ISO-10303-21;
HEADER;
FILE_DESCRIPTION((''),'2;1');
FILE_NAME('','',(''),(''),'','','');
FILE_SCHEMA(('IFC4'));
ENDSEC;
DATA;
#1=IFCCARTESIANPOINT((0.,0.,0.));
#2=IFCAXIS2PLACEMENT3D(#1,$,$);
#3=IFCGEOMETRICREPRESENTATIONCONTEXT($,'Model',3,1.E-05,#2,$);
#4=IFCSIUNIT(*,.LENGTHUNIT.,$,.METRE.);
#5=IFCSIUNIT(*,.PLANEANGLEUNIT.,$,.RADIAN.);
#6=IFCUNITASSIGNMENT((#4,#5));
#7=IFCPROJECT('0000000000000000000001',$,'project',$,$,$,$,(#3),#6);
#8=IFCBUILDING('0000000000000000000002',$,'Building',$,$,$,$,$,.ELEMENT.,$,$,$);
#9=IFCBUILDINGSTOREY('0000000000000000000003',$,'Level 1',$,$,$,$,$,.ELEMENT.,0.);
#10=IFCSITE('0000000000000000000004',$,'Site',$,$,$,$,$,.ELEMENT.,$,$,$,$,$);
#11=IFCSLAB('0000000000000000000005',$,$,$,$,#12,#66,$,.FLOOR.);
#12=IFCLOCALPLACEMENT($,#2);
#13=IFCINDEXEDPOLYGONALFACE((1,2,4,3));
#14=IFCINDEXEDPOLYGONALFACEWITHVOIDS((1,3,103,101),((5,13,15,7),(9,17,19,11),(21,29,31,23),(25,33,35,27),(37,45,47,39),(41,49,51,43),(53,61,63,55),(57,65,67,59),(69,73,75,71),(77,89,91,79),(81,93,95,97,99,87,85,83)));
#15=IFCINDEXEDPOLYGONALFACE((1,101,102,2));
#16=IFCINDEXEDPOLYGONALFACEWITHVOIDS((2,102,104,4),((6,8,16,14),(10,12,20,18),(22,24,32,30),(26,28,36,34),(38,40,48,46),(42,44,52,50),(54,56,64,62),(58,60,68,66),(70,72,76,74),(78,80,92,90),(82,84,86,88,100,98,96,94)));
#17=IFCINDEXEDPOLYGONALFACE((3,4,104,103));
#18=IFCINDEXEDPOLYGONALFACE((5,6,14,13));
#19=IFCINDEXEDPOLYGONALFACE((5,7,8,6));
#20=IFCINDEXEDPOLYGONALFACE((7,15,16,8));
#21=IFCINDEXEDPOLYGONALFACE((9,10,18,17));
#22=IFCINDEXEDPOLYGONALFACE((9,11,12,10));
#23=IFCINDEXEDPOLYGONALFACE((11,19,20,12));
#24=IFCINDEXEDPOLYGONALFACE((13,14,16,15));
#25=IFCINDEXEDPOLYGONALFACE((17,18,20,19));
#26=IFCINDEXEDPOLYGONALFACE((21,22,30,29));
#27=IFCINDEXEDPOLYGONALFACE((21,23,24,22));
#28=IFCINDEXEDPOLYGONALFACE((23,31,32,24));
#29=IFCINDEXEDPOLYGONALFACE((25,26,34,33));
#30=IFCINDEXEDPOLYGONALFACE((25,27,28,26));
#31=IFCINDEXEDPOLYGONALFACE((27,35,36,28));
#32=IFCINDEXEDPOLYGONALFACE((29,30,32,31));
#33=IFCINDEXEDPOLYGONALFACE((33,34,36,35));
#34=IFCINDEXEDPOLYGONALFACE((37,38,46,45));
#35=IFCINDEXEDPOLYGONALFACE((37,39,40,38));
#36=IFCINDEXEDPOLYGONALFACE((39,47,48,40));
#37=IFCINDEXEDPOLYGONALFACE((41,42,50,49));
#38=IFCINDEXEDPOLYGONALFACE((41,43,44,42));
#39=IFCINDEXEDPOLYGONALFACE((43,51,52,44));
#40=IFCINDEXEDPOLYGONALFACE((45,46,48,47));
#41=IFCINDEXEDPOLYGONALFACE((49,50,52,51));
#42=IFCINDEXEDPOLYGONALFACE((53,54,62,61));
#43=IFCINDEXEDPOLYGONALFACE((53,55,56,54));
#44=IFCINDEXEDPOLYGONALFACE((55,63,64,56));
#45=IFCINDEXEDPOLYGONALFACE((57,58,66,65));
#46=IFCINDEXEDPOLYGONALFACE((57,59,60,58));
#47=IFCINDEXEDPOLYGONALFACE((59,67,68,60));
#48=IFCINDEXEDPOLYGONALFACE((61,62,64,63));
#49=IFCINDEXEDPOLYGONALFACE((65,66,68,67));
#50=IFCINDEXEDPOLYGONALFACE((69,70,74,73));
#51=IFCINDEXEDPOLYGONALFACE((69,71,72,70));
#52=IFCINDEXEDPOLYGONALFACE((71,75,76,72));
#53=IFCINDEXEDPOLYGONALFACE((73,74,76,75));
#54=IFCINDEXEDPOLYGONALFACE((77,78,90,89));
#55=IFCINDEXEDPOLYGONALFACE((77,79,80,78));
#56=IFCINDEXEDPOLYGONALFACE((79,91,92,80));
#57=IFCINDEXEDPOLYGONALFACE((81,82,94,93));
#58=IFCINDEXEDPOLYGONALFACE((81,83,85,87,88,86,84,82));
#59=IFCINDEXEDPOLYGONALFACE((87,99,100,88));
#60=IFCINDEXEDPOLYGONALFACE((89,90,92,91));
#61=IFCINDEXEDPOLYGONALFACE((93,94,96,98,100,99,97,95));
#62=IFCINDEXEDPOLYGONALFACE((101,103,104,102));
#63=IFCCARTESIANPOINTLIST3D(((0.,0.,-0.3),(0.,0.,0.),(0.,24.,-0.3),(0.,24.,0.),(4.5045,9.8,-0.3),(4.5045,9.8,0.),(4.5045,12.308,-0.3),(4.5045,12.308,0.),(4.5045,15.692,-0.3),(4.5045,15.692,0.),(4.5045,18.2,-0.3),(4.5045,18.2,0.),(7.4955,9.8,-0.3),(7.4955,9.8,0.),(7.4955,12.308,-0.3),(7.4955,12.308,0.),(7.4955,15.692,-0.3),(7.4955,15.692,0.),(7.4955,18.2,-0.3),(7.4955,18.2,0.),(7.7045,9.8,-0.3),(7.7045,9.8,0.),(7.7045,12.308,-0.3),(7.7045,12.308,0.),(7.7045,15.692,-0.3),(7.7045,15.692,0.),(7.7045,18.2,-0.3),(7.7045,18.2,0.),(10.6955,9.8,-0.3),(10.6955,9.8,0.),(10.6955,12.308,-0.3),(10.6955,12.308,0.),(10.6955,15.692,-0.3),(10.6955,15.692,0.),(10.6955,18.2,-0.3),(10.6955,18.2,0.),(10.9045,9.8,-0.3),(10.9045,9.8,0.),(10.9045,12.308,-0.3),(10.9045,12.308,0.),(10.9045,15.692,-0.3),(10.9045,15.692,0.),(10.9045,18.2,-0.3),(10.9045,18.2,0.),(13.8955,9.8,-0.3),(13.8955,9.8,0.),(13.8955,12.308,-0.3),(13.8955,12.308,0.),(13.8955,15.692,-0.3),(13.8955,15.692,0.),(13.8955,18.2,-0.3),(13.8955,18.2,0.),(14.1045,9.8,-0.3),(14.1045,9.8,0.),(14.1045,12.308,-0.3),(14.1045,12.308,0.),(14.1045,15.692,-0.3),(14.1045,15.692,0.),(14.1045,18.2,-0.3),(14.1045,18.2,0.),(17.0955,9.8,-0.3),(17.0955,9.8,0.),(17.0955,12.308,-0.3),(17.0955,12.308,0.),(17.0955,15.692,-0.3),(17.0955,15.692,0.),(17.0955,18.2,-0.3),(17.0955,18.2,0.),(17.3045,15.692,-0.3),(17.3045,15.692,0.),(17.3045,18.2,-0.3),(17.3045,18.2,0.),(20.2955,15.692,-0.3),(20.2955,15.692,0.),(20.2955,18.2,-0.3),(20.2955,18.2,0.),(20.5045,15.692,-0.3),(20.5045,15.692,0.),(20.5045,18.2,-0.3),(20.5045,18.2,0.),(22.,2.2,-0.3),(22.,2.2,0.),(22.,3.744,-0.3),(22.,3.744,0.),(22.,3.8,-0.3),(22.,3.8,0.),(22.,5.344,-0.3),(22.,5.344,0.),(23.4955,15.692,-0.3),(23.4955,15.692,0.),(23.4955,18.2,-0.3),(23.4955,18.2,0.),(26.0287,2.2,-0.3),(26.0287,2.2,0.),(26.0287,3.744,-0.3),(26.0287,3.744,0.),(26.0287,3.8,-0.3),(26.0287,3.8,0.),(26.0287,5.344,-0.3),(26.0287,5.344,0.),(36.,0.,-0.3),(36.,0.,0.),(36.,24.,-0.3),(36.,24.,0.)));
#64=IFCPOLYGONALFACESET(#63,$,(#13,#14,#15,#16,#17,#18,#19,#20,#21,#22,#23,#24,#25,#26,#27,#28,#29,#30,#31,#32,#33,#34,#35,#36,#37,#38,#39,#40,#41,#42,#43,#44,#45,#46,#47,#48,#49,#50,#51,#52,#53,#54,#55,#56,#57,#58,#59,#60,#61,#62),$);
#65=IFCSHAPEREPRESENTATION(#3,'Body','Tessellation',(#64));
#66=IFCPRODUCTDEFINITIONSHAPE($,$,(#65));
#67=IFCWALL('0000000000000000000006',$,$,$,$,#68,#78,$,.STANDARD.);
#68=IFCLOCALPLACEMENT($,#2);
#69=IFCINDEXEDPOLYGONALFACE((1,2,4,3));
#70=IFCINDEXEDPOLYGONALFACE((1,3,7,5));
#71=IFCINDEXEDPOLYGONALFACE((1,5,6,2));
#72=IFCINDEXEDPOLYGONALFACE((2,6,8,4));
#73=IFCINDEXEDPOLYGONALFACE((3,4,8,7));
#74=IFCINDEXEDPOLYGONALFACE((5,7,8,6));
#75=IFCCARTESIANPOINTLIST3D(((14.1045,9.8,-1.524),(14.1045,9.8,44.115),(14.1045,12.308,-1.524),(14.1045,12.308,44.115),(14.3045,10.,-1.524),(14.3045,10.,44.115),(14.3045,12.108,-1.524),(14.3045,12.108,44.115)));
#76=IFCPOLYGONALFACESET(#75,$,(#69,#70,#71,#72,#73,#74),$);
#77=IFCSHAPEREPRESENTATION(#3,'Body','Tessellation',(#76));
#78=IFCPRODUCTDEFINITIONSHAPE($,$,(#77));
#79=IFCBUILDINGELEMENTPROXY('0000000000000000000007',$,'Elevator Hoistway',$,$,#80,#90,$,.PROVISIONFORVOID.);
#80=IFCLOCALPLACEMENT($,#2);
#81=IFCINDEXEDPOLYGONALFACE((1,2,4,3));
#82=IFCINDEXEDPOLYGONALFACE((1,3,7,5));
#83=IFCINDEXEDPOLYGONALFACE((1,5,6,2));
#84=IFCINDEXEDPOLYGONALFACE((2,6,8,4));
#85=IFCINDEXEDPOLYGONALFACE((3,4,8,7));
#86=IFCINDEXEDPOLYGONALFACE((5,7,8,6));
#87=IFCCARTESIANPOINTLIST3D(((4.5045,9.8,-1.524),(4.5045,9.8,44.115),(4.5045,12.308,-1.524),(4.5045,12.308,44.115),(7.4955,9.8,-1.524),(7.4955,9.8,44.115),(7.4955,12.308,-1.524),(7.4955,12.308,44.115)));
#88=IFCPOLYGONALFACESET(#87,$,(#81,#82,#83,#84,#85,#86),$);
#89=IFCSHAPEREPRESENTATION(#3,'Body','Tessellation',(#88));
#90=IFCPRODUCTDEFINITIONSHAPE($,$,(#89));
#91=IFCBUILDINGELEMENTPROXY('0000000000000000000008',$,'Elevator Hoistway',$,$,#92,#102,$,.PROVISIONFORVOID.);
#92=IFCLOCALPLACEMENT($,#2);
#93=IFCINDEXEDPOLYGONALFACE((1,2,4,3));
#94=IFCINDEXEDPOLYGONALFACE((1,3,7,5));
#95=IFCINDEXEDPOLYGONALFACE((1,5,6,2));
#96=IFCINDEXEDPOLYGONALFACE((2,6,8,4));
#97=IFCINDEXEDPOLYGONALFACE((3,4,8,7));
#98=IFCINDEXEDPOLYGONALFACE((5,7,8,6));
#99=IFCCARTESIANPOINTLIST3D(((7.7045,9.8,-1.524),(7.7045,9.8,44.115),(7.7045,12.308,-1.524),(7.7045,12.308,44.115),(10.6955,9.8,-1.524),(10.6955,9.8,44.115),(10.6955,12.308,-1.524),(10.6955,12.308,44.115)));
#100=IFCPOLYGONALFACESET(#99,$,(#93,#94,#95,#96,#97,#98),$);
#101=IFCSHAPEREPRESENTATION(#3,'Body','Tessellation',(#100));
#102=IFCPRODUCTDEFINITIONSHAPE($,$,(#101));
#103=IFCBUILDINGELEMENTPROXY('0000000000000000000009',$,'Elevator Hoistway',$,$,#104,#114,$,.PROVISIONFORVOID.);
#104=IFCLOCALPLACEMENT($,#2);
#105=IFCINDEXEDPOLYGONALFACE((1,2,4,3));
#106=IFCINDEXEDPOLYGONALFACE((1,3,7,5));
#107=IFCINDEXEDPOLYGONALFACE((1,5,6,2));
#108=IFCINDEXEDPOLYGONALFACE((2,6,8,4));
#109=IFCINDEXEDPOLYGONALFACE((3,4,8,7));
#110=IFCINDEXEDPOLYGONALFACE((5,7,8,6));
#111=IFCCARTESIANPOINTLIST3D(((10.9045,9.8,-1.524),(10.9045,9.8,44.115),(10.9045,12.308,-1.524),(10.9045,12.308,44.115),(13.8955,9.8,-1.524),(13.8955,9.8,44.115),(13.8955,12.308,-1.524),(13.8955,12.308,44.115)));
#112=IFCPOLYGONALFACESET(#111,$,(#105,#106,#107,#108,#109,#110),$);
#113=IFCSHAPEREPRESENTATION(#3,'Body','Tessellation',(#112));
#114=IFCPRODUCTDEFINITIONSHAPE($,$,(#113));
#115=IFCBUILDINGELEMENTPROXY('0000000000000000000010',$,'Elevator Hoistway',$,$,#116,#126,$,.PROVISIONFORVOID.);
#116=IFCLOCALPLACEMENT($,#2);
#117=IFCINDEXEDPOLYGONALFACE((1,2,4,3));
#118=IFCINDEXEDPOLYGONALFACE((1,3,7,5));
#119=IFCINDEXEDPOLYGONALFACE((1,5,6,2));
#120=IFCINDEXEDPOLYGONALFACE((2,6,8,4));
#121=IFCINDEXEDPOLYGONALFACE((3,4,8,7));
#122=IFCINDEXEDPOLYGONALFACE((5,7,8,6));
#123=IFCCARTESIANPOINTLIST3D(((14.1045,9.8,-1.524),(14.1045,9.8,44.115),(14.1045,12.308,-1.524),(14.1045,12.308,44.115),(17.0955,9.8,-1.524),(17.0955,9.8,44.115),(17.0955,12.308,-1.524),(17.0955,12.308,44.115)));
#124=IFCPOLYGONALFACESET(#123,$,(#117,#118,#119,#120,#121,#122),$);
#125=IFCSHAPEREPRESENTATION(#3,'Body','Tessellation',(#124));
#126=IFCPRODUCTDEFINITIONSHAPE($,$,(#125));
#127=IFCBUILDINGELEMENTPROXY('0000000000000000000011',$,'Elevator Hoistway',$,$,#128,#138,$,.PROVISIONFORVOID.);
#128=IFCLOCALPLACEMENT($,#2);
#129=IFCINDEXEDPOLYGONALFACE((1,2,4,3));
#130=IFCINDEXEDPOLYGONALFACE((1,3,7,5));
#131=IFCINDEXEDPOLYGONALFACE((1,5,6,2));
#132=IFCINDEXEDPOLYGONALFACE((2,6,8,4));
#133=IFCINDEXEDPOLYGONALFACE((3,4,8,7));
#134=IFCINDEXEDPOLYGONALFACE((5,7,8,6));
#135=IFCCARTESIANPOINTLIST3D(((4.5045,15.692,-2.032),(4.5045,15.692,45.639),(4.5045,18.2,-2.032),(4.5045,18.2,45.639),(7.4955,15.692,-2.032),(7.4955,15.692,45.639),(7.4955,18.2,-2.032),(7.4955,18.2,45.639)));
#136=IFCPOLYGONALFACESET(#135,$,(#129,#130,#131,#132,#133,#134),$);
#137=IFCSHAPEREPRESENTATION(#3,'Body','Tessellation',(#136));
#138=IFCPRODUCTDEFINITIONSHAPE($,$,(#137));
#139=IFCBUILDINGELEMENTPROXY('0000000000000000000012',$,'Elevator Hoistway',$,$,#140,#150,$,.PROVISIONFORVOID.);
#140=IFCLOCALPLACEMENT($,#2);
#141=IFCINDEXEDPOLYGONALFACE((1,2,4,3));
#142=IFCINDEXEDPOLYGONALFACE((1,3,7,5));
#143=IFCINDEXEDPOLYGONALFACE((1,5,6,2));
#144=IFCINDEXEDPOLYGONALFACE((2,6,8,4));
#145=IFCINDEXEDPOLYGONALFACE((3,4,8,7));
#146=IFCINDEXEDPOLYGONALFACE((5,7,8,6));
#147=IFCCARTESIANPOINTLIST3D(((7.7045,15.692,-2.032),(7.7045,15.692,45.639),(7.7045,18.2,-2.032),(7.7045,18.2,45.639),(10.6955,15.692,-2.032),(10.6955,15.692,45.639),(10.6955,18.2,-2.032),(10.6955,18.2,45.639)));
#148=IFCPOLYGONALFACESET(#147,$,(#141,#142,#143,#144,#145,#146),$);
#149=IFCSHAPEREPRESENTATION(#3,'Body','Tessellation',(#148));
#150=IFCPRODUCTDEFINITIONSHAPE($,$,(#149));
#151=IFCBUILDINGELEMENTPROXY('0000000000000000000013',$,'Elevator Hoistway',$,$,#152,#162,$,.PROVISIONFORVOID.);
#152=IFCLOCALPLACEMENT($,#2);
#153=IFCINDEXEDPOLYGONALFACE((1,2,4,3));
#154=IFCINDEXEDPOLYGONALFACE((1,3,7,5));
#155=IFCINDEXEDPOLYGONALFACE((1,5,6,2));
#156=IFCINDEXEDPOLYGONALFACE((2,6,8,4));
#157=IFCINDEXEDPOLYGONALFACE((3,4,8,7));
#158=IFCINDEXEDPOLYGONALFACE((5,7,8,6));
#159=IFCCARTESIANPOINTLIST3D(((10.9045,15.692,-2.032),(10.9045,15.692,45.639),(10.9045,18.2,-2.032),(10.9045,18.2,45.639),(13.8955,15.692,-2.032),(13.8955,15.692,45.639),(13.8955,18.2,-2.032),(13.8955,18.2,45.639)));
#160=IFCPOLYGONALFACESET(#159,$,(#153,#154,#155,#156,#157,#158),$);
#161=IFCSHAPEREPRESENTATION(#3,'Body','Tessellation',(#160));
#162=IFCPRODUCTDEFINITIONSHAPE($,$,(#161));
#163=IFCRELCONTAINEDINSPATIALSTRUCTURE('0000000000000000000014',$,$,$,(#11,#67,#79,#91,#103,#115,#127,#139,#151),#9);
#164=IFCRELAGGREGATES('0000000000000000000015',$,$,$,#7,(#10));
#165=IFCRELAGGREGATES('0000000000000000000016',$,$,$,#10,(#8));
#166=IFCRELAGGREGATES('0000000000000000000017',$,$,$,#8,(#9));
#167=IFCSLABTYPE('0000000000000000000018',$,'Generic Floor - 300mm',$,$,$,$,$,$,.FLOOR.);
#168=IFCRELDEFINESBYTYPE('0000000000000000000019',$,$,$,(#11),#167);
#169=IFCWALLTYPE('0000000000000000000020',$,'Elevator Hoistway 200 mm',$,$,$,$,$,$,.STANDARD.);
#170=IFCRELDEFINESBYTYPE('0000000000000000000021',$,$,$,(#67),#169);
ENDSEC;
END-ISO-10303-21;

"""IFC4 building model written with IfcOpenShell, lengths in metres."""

from ifc_helpers import new_model, si_unit, frame, origin, place, context, project, spatial, polyline, outline, extrude, type_object, element, save


model = new_model("IFC4")

# Units and contexts
model_context = context("Model", 3, precision=1e-05, world=origin())
ifc_project = project(units=[si_unit("LENGTHUNIT", "METRE"), si_unit("PLANEANGLEUNIT", "RADIAN")], contexts=[model_context])

# Site, building, storey
site = spatial("IfcSite", under=ifc_project, Name="Site", CompositionType="ELEMENT")
building = spatial("IfcBuilding", under=site, Name="Building", CompositionType="ELEMENT")
storey = spatial("IfcBuildingStorey", under=building, Name="Level 1", CompositionType="ELEMENT", Elevation=0.0)

# Slab, openings
slab_type = type_object("IfcSlabType", Name="Generic Floor - 300mm", PredefinedType="FLOOR")
slab_placement = place(None, origin())
slab = element("IfcSlab", 1, at=slab_placement, inside=storey, type_object=slab_type, PredefinedType="FLOOR", context=model_context, shape_type="SweptSolid", body=[
    extrude(outline(polyline([(0.0, 0.0), (36.0, 0.0), (36.0, 24.0), (0.0, 24.0), (0.0, 0.0)])), origin(), (0.0, 0.0, -1.0), 0.3),
])
opening_1_placement = place(None, frame((0.0, 0.0, 0.001)))
element("IfcOpeningElement", 2, at=opening_1_placement, cuts=slab, PredefinedType="OPENING", context=model_context, shape_type="SweptSolid", body=[
    extrude(outline(polyline([(4.5045, 9.8), (7.4955, 9.8), (7.4955, 12.308), (4.5045, 12.308), (4.5045, 9.8)])), origin(), (0.0, 0.0, -1.0), 0.302),
])
opening_2_placement = place(None, frame((0.0, 0.0, 0.001)))
element("IfcOpeningElement", 3, at=opening_2_placement, cuts=slab, PredefinedType="OPENING", context=model_context, shape_type="SweptSolid", body=[
    extrude(outline(polyline([(7.7045, 9.8), (10.6955, 9.8), (10.6955, 12.308), (7.7045, 12.308), (7.7045, 9.8)])), origin(), (0.0, 0.0, -1.0), 0.302),
])
opening_3_placement = place(None, frame((0.0, 0.0, 0.001)))
element("IfcOpeningElement", 4, at=opening_3_placement, cuts=slab, PredefinedType="OPENING", context=model_context, shape_type="SweptSolid", body=[
    extrude(outline(polyline([(10.9045, 9.8), (13.8955, 9.8), (13.8955, 12.308), (10.9045, 12.308), (10.9045, 9.8)])), origin(), (0.0, 0.0, -1.0), 0.302),
])
opening_4_placement = place(None, frame((0.0, 0.0, 0.001)))
element("IfcOpeningElement", 5, at=opening_4_placement, cuts=slab, PredefinedType="OPENING", context=model_context, shape_type="SweptSolid", body=[
    extrude(outline(polyline([(14.1045, 9.8), (17.0955, 9.8), (17.0955, 12.308), (14.1045, 12.308), (14.1045, 9.8)])), origin(), (0.0, 0.0, -1.0), 0.302),
])
opening_5_placement = place(None, frame((0.0, 0.0, 0.001)))
element("IfcOpeningElement", 6, at=opening_5_placement, cuts=slab, PredefinedType="OPENING", context=model_context, shape_type="SweptSolid", body=[
    extrude(outline(polyline([(7.4955, 18.2), (4.5045, 18.2), (4.5045, 15.692), (7.4955, 15.692), (7.4955, 18.2)])), origin(), (0.0, 0.0, -1.0), 0.302),
])
opening_6_placement = place(None, frame((0.0, 0.0, 0.001)))
element("IfcOpeningElement", 7, at=opening_6_placement, cuts=slab, PredefinedType="OPENING", context=model_context, shape_type="SweptSolid", body=[
    extrude(outline(polyline([(10.6955, 18.2), (7.7045, 18.2), (7.7045, 15.692), (10.6955, 15.692), (10.6955, 18.2)])), origin(), (0.0, 0.0, -1.0), 0.302),
])
opening_7_placement = place(None, frame((0.0, 0.0, 0.001)))
element("IfcOpeningElement", 8, at=opening_7_placement, cuts=slab, PredefinedType="OPENING", context=model_context, shape_type="SweptSolid", body=[
    extrude(outline(polyline([(13.8955, 18.2), (10.9045, 18.2), (10.9045, 15.692), (13.8955, 15.692), (13.8955, 18.2)])), origin(), (0.0, 0.0, -1.0), 0.302),
])
opening_8_placement = place(None, frame((0.0, 0.0, 0.001)))
element("IfcOpeningElement", 9, at=opening_8_placement, cuts=slab, PredefinedType="OPENING", context=model_context, shape_type="SweptSolid", body=[
    extrude(outline(polyline([(17.0955, 18.2), (14.1045, 18.2), (14.1045, 15.692), (17.0955, 15.692), (17.0955, 18.2)])), origin(), (0.0, 0.0, -1.0), 0.302),
])
opening_9_placement = place(None, frame((0.0, 0.0, 0.001)))
element("IfcOpeningElement", 10, at=opening_9_placement, cuts=slab, PredefinedType="OPENING", context=model_context, shape_type="SweptSolid", body=[
    extrude(outline(polyline([(20.2955, 18.2), (17.3045, 18.2), (17.3045, 15.692), (20.2955, 15.692), (20.2955, 18.2)])), origin(), (0.0, 0.0, -1.0), 0.302),
])
opening_10_placement = place(None, frame((0.0, 0.0, 0.001)))
element("IfcOpeningElement", 11, at=opening_10_placement, cuts=slab, PredefinedType="OPENING", context=model_context, shape_type="SweptSolid", body=[
    extrude(outline(polyline([(23.4955, 18.2), (20.5045, 18.2), (20.5045, 15.692), (23.4955, 15.692), (23.4955, 18.2)])), origin(), (0.0, 0.0, -1.0), 0.302),
])
opening_11_placement = place(None, frame((0.0, 0.0, 0.001)))
element("IfcOpeningElement", 12, at=opening_11_placement, cuts=slab, PredefinedType="OPENING", context=model_context, shape_type="SweptSolid", body=[
    extrude(outline(polyline([(22.0, 2.2), (26.0287, 2.2), (26.0287, 3.8), (22.0, 3.8), (22.0, 2.2)])), origin(), (0.0, 0.0, -1.0), 0.302),
])
opening_12_placement = place(None, frame((0.0, 0.0, 0.001)))
element("IfcOpeningElement", 13, at=opening_12_placement, cuts=slab, PredefinedType="OPENING", context=model_context, shape_type="SweptSolid", body=[
    extrude(outline(polyline([(22.0, 3.744), (26.0287, 3.744), (26.0287, 5.344), (22.0, 5.344), (22.0, 3.744)])), origin(), (0.0, 0.0, -1.0), 0.302),
])

# Wall
wall_type = type_object("IfcWallType", Name="Elevator Hoistway 200 mm", PredefinedType="STANDARD")
wall_placement = place(None, frame((14.2045, 12.208, -1.524), z_axis=(0.0, 0.0, 1.0), x_axis=(0.0, -1.0, 0.0)))
element("IfcWall", 14, at=wall_placement, inside=storey, type_object=wall_type, PredefinedType="STANDARD", context=model_context, shape_type="SweptSolid", body=[
    extrude(outline(polyline([(-0.1, -0.1), (2.408, -0.1), (2.208, 0.1), (0.1, 0.1), (-0.1, -0.1)])), origin(), (0.0, 0.0, 1.0), 45.639),
])

# Building element proxies
proxy_1_placement = place(None, frame((0.0, 0.0, 44.115)))
element("IfcBuildingElementProxy", 15, at=proxy_1_placement, inside=storey, Name="Elevator Hoistway", PredefinedType="PROVISIONFORVOID", context=model_context, shape_type="SweptSolid", body=[
    extrude(outline(polyline([(4.5045, 9.8), (7.4955, 9.8), (7.4955, 12.308), (4.5045, 12.308), (4.5045, 9.8)])), origin(), (0.0, 0.0, -1.0), 45.639),
])
proxy_2_placement = place(None, frame((0.0, 0.0, 44.115)))
element("IfcBuildingElementProxy", 16, at=proxy_2_placement, inside=storey, Name="Elevator Hoistway", PredefinedType="PROVISIONFORVOID", context=model_context, shape_type="SweptSolid", body=[
    extrude(outline(polyline([(7.7045, 9.8), (10.6955, 9.8), (10.6955, 12.308), (7.7045, 12.308), (7.7045, 9.8)])), origin(), (0.0, 0.0, -1.0), 45.639),
])
proxy_3_placement = place(None, frame((0.0, 0.0, 44.115)))
element("IfcBuildingElementProxy", 17, at=proxy_3_placement, inside=storey, Name="Elevator Hoistway", PredefinedType="PROVISIONFORVOID", context=model_context, shape_type="SweptSolid", body=[
    extrude(outline(polyline([(10.9045, 9.8), (13.8955, 9.8), (13.8955, 12.308), (10.9045, 12.308), (10.9045, 9.8)])), origin(), (0.0, 0.0, -1.0), 45.639),
])
proxy_4_placement = place(None, frame((0.0, 0.0, 44.115)))
element("IfcBuildingElementProxy", 18, at=proxy_4_placement, inside=storey, Name="Elevator Hoistway", PredefinedType="PROVISIONFORVOID", context=model_context, shape_type="SweptSolid", body=[
    extrude(outline(polyline([(14.1045, 9.8), (17.0955, 9.8), (17.0955, 12.308), (14.1045, 12.308), (14.1045, 9.8)])), origin(), (0.0, 0.0, -1.0), 45.639),
])
proxy_5_placement = place(None, frame((0.0, 0.0, 45.639)))
element("IfcBuildingElementProxy", 19, at=proxy_5_placement, inside=storey, Name="Elevator Hoistway", PredefinedType="PROVISIONFORVOID", context=model_context, shape_type="SweptSolid", body=[
    extrude(outline(polyline([(7.4955, 18.2), (4.5045, 18.2), (4.5045, 15.692), (7.4955, 15.692), (7.4955, 18.2)])), origin(), (0.0, 0.0, -1.0), 47.671),
])
proxy_6_placement = place(None, frame((0.0, 0.0, 45.639)))
element("IfcBuildingElementProxy", 20, at=proxy_6_placement, inside=storey, Name="Elevator Hoistway", PredefinedType="PROVISIONFORVOID", context=model_context, shape_type="SweptSolid", body=[
    extrude(outline(polyline([(10.6955, 18.2), (7.7045, 18.2), (7.7045, 15.692), (10.6955, 15.692), (10.6955, 18.2)])), origin(), (0.0, 0.0, -1.0), 47.671),
])
proxy_7_placement = place(None, frame((0.0, 0.0, 45.639)))
element("IfcBuildingElementProxy", 21, at=proxy_7_placement, inside=storey, Name="Elevator Hoistway", PredefinedType="PROVISIONFORVOID", context=model_context, shape_type="SweptSolid", body=[
    extrude(outline(polyline([(13.8955, 18.2), (10.9045, 18.2), (10.9045, 15.692), (13.8955, 15.692), (13.8955, 18.2)])), origin(), (0.0, 0.0, -1.0), 47.671),
])

save(model, "model.ifc")
